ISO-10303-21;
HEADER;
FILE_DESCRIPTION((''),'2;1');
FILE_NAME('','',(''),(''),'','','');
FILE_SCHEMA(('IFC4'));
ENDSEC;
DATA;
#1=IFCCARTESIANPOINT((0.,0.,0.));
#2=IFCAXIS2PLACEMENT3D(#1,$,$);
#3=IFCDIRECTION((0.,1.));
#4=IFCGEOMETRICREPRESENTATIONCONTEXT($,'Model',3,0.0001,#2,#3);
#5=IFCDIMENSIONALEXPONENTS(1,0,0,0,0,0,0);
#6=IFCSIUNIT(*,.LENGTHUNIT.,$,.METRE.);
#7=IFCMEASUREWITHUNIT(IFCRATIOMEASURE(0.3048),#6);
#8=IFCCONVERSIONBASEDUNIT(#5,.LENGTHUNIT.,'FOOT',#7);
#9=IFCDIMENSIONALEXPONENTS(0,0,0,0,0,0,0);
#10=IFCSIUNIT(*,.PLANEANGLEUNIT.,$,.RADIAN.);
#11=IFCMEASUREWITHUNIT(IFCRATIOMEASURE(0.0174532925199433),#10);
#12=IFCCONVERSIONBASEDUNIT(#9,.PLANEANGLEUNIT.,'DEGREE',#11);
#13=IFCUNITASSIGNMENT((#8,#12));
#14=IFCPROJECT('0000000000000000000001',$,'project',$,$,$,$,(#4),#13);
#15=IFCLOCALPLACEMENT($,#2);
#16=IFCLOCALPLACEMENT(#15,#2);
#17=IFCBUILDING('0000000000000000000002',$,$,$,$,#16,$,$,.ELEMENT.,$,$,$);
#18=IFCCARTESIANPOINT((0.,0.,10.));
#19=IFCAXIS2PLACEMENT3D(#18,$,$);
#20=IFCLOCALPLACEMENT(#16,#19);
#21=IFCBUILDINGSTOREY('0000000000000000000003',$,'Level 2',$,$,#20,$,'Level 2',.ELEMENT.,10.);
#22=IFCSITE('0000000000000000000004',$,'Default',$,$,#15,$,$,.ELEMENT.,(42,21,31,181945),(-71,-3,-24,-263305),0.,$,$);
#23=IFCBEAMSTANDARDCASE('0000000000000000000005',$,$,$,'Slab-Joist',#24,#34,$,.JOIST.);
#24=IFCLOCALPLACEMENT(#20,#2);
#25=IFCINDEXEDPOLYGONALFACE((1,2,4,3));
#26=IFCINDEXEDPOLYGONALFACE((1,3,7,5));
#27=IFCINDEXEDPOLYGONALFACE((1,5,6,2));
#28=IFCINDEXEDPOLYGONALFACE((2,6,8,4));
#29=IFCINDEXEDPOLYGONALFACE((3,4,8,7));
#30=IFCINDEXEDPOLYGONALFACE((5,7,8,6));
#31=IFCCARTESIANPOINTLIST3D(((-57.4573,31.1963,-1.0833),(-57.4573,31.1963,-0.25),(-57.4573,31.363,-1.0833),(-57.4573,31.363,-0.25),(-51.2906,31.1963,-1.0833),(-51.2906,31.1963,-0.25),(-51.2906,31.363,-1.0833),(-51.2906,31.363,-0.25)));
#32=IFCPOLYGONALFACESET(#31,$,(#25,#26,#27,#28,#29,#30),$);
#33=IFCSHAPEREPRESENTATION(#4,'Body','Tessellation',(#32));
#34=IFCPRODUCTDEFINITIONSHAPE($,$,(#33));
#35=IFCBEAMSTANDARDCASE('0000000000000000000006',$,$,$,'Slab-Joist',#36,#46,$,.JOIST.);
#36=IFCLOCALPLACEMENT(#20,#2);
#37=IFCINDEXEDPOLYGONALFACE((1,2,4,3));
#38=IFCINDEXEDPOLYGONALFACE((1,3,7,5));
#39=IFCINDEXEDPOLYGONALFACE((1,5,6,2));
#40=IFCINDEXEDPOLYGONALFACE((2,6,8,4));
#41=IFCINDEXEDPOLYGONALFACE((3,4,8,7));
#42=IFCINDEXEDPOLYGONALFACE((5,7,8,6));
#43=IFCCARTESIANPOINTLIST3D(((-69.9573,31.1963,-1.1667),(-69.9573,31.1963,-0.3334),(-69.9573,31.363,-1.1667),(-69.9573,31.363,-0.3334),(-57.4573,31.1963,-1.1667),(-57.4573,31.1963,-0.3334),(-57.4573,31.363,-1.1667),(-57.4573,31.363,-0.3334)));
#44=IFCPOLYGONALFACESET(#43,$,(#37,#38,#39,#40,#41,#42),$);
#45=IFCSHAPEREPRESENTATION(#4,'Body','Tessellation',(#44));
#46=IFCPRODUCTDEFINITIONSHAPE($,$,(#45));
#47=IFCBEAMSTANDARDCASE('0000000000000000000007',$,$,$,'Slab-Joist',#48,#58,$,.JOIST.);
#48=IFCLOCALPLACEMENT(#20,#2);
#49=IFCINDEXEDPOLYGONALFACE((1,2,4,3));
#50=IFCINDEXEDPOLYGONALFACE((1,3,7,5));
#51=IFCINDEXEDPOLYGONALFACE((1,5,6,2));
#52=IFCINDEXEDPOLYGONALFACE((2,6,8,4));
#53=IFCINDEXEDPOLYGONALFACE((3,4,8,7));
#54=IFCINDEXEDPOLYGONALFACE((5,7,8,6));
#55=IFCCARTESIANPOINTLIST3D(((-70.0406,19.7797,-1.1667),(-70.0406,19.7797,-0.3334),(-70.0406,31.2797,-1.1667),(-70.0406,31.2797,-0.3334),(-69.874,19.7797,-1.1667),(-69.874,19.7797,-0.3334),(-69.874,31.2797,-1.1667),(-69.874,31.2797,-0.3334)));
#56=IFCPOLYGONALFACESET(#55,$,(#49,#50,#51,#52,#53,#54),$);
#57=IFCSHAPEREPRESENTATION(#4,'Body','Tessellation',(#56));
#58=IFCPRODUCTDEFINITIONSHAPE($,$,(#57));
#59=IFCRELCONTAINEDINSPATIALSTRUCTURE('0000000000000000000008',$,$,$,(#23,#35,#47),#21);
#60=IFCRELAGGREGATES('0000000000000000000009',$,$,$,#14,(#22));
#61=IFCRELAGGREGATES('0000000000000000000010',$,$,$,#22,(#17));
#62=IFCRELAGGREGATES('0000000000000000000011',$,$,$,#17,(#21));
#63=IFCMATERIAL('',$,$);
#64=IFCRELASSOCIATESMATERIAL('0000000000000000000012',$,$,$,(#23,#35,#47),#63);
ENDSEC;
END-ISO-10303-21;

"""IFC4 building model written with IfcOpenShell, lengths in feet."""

from ifc_helpers import new_model, entity, si_unit, converted_unit, direction, frame, origin, origin_with_axes, place, context, project, spatial, rectangle, extrude, material, element, save


model = new_model("IFC4")

# Units and contexts
model_context = context("Model", 3, precision=0.0001, world=origin(), true_north=direction((0.0, 1.0)))
ifc_project = project(units=[converted_unit("LENGTHUNIT", "FOOT", entity("IfcRatioMeasure", 0.3048), si_unit("LENGTHUNIT", "METRE"), dimensions=[1, 0, 0, 0, 0, 0, 0]), converted_unit("PLANEANGLEUNIT", "DEGREE", entity("IfcRatioMeasure", 0.0174532925199433), si_unit("PLANEANGLEUNIT", "RADIAN"), dimensions=[0, 0, 0, 0, 0, 0, 0])], contexts=[model_context])

# Site, building, storey
site_placement = place(None, origin())
site = spatial("IfcSite", under=ifc_project, at=site_placement, Name="Default", CompositionType="ELEMENT", RefLatitude=(42, 21, 31, 181945), RefLongitude=(-71, -3, -24, -263305), RefElevation=0.0)
building_placement = place(site_placement, origin())
building = spatial("IfcBuilding", under=site, at=building_placement, CompositionType="ELEMENT")
storey_placement = place(building_placement, frame((0.0, 0.0, 10.0)))
storey = spatial("IfcBuildingStorey", under=building, at=storey_placement, Name="Level 2", LongName="Level 2", CompositionType="ELEMENT", Elevation=10.0)

# Beams
ifc_material = material(Name="")
placement_1 = place(storey_placement, frame((-57.4573, 31.2797, 0.0), z_axis=(0.0, 0.0, 1.0), x_axis=(1.0, 0.0, 0.0)))
beam_1_placement = place(placement_1, frame((0.0, 0.0, -0.6667), z_axis=(1.0, 0.0, 0.0), x_axis=(0.0, 1.0, 0.0)))
element("IfcBeamStandardCase", 1, at=beam_1_placement, inside=storey, material=ifc_material, ObjectType="Slab-Joist", PredefinedType="JOIST", context=model_context, shape_type="SweptSolid", body=[
    extrude(rectangle(XDim=0.1667, YDim=0.8333), origin_with_axes(), (0.0, 0.0, 1.0), 6.1667),
])
placement_2 = place(storey_placement, frame((-69.9573, 31.2797, 0.0), z_axis=(0.0, 0.0, 1.0), x_axis=(1.0, 0.0, 0.0)))
beam_2_placement = place(placement_2, frame((0.0, 0.0, -0.75), z_axis=(1.0, 0.0, 0.0), x_axis=(0.0, 1.0, 0.0)))
element("IfcBeamStandardCase", 2, at=beam_2_placement, inside=storey, material=ifc_material, ObjectType="Slab-Joist", PredefinedType="JOIST", context=model_context, shape_type="SweptSolid", body=[
    extrude(rectangle(XDim=0.1667, YDim=0.8333), origin_with_axes(), (0.0, 0.0, 1.0), 12.5),
])
placement_3 = place(storey_placement, frame((-69.9573, 19.7797, 0.0), z_axis=(0.0, 0.0, 1.0), x_axis=(1.0, 0.0, 0.0)))
beam_3_placement = place(placement_3, frame((0.0, 0.0, -0.75), z_axis=(0.0, 1.0, 0.0), x_axis=(-1.0, 0.0, 0.0)))
element("IfcBeamStandardCase", 3, at=beam_3_placement, inside=storey, material=ifc_material, ObjectType="Slab-Joist", PredefinedType="JOIST", context=model_context, shape_type="SweptSolid", body=[
    extrude(rectangle(XDim=0.1667, YDim=0.8333), origin_with_axes(), (0.0, 0.0, 1.0), 11.5),
])

save(model, "model.ifc")
